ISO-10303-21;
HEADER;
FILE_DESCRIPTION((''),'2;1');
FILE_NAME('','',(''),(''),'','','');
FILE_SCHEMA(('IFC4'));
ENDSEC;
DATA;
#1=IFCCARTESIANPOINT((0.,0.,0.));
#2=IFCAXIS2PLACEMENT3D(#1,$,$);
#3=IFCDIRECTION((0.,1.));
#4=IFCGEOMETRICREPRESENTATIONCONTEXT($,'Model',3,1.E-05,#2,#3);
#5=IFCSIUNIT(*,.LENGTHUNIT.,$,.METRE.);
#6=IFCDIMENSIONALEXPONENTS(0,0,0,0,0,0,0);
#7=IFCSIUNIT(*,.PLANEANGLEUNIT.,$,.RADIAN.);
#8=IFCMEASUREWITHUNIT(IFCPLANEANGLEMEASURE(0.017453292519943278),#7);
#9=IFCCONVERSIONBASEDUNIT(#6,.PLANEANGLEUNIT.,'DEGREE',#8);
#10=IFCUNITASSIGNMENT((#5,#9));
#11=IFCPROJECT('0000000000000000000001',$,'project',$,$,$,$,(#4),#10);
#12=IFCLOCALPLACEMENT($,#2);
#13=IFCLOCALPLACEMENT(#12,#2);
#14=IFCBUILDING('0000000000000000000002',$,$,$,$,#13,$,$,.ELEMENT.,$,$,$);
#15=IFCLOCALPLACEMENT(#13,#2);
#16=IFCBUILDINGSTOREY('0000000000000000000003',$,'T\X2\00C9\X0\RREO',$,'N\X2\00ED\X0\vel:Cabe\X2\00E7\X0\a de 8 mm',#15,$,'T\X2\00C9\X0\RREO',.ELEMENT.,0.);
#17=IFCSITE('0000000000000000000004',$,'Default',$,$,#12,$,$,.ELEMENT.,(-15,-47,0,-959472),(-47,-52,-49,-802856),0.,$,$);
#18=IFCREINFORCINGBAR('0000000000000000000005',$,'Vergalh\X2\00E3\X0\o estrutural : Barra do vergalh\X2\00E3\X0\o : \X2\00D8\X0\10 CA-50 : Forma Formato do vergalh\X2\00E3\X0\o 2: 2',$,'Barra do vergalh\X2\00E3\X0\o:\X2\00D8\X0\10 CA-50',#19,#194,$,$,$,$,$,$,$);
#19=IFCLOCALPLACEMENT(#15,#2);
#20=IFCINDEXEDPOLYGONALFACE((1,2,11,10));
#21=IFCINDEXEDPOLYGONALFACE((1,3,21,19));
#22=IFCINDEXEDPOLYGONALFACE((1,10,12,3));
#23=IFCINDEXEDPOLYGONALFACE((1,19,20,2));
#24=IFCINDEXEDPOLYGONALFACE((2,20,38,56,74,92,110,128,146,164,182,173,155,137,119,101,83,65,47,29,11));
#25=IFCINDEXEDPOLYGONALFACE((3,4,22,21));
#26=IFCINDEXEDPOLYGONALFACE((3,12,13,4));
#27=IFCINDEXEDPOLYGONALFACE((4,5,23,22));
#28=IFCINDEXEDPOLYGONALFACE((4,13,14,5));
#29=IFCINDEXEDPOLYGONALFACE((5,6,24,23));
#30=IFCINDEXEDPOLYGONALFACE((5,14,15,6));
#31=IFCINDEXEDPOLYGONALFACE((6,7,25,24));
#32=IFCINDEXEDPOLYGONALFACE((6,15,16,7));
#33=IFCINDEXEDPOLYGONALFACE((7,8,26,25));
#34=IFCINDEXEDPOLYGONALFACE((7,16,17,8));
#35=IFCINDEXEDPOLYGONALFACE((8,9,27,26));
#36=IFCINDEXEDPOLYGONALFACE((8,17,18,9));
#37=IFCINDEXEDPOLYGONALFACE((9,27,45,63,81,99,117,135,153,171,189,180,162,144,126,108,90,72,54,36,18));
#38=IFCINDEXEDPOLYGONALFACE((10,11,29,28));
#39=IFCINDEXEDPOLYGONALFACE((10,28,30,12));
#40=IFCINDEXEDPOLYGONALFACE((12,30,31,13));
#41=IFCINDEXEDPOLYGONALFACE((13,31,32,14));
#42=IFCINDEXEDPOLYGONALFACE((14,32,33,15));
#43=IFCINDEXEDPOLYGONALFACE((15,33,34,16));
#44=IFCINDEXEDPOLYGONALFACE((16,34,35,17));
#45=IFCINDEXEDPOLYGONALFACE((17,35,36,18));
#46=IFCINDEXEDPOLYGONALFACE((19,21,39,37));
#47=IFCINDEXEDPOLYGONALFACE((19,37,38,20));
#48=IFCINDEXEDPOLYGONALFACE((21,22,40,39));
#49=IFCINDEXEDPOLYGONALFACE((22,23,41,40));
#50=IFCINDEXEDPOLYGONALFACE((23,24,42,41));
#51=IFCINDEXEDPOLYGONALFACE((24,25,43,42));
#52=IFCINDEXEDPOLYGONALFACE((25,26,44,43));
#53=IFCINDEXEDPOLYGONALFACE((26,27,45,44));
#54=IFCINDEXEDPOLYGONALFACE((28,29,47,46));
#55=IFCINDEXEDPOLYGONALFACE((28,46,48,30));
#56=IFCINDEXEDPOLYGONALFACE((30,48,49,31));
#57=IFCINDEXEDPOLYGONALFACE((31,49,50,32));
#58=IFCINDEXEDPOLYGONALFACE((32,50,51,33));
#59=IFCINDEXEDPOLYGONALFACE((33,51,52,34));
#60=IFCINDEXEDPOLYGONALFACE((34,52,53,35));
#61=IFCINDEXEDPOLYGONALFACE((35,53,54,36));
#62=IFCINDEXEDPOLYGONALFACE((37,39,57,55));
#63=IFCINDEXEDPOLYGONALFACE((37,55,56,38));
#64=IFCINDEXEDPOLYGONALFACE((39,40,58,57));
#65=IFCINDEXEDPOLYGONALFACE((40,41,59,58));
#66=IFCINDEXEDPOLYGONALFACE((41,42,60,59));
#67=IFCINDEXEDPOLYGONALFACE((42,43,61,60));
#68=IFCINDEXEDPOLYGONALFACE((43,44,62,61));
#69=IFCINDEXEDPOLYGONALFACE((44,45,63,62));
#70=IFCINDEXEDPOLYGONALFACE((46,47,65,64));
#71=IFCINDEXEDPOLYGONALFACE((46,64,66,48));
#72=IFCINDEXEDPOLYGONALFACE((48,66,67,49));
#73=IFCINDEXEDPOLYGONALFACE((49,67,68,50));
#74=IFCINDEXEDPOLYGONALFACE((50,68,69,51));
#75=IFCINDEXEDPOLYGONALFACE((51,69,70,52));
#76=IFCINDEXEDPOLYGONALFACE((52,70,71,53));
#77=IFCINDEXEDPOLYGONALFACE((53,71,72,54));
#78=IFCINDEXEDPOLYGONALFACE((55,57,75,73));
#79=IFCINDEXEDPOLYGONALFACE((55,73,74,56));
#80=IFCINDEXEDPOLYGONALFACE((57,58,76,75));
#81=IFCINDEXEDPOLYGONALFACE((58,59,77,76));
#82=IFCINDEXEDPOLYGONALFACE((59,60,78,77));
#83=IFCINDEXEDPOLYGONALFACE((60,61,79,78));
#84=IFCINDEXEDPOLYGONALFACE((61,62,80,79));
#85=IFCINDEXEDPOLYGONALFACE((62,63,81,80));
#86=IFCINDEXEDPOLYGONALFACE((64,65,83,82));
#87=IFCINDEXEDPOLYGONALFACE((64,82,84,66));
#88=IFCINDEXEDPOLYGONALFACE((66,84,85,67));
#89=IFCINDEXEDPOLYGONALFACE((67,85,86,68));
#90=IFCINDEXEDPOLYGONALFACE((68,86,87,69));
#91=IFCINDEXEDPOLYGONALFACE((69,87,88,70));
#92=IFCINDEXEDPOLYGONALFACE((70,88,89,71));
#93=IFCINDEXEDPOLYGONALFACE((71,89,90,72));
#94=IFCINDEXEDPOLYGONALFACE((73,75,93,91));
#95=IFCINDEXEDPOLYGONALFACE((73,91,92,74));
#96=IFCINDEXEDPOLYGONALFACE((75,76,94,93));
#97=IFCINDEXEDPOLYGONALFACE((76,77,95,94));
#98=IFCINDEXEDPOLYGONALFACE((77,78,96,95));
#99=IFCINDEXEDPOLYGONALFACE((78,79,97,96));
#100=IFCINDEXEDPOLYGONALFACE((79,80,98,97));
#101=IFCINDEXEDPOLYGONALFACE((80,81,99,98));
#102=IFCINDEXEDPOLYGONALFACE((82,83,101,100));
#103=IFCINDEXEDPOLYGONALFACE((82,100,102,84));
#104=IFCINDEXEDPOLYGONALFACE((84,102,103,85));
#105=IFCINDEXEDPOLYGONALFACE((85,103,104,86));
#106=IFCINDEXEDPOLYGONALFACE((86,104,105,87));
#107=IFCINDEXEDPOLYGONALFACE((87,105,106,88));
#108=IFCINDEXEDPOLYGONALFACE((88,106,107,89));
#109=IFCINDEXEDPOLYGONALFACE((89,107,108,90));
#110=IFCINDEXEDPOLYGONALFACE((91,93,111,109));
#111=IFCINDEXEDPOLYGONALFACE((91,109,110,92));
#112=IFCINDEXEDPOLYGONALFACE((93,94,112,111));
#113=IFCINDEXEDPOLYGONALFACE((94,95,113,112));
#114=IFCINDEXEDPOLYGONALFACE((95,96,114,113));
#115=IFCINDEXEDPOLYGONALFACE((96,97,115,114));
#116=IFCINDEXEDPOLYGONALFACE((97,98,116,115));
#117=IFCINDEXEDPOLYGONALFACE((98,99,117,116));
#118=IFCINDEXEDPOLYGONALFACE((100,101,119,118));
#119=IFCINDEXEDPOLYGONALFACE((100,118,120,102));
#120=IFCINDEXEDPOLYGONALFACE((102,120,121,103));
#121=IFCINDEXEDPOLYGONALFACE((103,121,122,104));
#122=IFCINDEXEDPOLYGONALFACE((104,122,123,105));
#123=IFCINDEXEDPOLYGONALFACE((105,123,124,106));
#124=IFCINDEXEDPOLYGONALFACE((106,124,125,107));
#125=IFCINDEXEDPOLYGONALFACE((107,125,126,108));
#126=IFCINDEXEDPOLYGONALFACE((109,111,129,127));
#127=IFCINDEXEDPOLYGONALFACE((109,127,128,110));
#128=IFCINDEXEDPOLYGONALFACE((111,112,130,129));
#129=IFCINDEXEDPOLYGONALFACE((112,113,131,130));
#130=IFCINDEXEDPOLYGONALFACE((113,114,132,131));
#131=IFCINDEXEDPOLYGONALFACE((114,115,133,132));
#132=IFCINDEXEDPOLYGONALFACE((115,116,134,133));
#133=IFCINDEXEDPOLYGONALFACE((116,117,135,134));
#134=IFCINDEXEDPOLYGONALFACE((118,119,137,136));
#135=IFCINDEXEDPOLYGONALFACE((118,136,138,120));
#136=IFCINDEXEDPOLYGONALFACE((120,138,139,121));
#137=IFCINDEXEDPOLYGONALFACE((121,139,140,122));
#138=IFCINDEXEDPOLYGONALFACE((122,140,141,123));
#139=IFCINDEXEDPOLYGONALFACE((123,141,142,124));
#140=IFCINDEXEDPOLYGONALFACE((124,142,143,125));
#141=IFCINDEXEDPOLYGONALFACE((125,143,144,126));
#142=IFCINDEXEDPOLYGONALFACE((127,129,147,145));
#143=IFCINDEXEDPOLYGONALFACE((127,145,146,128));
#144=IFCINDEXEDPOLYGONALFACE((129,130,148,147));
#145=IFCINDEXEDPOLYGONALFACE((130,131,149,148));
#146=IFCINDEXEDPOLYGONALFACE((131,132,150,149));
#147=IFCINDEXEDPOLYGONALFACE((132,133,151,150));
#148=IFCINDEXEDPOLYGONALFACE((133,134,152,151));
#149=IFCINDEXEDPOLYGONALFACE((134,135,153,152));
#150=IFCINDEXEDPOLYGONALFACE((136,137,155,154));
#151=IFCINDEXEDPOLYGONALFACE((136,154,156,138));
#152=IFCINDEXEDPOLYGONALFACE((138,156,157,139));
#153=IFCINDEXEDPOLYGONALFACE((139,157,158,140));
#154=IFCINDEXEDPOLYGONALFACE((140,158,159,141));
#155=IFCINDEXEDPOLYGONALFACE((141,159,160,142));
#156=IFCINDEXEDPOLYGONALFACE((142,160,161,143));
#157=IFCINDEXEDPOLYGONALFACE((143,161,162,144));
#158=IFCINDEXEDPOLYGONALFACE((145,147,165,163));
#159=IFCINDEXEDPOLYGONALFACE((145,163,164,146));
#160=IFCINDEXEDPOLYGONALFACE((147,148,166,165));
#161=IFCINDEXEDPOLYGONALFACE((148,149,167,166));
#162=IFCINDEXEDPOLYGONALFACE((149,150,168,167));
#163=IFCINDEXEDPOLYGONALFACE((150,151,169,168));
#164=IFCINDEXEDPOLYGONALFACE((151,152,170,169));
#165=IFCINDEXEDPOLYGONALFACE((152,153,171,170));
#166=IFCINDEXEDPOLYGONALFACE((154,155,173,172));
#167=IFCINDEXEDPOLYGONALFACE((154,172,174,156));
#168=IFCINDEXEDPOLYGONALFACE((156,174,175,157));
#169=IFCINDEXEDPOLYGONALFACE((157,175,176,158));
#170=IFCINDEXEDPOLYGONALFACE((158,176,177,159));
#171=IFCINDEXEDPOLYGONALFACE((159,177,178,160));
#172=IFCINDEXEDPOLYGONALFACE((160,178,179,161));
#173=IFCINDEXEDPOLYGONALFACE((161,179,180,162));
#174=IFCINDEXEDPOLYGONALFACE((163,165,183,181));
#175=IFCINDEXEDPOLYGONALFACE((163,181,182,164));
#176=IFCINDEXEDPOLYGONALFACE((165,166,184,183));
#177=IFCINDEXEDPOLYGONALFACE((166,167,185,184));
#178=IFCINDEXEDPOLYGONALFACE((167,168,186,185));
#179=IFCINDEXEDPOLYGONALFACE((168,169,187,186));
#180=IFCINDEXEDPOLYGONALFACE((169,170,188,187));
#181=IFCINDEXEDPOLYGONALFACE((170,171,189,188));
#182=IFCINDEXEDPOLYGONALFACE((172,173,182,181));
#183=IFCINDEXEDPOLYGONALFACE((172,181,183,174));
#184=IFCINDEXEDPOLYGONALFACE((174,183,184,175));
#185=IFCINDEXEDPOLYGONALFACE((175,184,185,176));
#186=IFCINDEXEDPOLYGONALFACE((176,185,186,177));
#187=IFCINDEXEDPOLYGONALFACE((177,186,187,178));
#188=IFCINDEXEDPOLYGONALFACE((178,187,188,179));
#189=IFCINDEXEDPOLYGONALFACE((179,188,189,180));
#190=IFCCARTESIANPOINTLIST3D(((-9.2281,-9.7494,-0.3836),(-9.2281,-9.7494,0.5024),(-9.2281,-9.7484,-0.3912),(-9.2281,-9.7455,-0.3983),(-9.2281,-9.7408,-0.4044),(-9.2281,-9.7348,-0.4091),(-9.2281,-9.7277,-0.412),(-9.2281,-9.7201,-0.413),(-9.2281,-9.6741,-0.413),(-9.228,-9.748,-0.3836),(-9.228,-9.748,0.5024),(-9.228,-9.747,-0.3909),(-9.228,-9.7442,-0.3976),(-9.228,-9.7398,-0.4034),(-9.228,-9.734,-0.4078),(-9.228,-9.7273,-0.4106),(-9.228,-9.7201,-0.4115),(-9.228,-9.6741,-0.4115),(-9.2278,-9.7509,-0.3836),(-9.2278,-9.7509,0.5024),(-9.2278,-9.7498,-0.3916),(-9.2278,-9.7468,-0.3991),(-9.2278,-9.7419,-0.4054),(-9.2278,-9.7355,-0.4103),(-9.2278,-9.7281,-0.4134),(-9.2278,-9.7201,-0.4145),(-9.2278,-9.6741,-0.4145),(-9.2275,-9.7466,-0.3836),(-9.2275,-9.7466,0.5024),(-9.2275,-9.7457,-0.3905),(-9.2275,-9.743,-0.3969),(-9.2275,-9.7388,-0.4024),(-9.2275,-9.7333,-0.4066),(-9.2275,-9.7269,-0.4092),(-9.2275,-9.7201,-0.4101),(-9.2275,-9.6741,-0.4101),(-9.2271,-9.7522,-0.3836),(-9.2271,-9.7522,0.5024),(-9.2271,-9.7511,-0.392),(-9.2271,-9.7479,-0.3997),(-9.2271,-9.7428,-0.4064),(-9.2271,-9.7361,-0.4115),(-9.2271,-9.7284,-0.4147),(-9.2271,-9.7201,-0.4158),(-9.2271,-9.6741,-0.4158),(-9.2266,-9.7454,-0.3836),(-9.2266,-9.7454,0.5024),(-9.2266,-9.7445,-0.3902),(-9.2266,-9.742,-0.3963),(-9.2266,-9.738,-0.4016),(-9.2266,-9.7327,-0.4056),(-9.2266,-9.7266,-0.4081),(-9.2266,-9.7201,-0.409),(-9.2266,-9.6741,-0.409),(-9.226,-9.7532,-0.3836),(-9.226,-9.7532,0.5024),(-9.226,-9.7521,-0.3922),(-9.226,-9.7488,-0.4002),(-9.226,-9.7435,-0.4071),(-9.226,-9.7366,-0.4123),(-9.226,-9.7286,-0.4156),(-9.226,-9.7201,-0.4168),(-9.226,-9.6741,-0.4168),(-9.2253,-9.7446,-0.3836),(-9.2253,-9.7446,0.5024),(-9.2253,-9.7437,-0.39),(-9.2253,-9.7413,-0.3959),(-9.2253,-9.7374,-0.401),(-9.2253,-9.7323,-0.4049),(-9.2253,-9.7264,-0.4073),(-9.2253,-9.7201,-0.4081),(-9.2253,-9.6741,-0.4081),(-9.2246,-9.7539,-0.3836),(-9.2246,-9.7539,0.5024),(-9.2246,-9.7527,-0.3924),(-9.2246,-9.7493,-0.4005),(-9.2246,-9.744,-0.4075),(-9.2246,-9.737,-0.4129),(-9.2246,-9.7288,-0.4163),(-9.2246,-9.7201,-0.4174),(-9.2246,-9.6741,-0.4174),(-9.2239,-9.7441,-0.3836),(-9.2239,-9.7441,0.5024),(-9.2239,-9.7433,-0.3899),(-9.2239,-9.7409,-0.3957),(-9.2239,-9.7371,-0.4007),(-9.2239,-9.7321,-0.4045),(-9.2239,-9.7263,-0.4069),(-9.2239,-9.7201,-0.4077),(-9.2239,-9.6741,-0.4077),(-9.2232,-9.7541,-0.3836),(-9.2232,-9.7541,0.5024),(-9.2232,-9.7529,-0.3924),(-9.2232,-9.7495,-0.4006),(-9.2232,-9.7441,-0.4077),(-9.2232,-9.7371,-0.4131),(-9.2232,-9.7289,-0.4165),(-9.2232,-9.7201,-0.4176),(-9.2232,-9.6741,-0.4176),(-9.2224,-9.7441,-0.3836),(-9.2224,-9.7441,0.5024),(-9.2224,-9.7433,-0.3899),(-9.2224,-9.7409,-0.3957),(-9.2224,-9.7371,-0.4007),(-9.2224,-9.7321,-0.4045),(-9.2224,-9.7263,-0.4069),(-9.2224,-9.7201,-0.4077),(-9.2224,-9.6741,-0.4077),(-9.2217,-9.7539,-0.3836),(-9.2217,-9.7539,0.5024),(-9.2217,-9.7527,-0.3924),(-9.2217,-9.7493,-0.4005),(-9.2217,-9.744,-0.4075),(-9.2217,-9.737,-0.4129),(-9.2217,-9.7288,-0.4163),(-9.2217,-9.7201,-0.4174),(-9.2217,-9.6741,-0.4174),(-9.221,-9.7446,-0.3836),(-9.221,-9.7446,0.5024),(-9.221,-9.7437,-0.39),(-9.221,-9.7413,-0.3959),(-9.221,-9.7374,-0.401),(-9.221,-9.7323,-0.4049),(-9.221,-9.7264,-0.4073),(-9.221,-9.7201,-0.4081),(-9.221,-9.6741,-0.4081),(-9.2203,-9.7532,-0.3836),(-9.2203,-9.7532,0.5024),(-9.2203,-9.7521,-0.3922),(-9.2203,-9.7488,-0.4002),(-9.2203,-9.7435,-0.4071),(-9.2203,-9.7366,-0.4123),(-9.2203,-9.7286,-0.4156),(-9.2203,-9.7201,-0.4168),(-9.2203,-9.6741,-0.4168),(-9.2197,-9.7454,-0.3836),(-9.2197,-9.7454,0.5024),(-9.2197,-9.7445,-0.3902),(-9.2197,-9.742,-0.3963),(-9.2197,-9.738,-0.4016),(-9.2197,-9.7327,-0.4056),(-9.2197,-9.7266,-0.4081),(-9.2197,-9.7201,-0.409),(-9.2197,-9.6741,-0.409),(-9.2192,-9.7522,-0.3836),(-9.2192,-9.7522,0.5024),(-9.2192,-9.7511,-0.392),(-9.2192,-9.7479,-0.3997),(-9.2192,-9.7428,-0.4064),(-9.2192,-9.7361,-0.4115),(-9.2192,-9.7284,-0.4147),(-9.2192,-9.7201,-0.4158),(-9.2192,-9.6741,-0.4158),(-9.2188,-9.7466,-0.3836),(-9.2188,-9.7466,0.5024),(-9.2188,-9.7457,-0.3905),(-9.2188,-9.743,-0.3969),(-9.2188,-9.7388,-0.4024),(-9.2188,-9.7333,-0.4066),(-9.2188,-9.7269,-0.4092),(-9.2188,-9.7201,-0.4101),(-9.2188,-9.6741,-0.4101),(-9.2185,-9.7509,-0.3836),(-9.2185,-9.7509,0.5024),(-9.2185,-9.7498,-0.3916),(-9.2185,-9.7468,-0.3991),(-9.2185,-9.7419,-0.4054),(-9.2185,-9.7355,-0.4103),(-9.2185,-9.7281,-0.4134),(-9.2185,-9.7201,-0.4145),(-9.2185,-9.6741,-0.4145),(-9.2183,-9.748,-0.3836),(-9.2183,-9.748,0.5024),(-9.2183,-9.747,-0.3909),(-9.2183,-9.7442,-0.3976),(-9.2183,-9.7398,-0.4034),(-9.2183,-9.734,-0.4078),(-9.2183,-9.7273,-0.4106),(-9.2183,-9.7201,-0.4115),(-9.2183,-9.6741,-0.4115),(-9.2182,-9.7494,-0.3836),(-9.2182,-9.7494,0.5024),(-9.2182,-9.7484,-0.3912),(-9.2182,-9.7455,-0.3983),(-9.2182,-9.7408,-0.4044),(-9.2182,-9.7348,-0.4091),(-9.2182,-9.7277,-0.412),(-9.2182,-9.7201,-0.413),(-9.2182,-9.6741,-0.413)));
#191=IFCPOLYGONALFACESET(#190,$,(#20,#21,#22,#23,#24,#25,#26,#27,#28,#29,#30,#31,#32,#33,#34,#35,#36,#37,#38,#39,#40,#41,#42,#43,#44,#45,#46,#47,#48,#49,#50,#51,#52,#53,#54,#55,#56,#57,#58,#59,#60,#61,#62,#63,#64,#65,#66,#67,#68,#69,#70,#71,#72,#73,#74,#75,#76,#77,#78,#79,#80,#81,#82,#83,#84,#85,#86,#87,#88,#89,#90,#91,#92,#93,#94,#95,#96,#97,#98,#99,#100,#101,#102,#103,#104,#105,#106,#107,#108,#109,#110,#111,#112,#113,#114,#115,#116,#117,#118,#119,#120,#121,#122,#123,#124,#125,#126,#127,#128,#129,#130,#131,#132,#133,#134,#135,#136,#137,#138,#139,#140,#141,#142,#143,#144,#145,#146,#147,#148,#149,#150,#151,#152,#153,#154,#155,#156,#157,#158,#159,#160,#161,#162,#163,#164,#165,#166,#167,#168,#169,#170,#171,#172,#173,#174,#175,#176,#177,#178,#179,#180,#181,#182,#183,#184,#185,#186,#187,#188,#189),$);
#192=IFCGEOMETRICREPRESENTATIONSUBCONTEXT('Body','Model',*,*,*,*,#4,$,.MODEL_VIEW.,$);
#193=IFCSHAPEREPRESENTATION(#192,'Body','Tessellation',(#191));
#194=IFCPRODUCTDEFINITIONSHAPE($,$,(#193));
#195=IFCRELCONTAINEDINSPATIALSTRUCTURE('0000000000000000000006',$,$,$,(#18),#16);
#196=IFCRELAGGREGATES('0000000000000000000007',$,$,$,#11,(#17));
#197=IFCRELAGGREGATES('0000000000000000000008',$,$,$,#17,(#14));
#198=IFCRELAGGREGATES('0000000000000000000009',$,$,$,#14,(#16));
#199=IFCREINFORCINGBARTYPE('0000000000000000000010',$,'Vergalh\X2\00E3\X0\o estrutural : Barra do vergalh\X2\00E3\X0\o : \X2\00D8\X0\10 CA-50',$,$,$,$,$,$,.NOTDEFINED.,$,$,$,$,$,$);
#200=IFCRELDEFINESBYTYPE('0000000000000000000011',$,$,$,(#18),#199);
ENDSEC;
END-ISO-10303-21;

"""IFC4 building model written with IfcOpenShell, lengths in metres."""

from ifc_helpers import new_model, entity, si_unit, converted_unit, direction, origin, place, context, subcontext, project, spatial, type_object, element, save


model = new_model("IFC4")

# Units and contexts
model_context = context("Model", 3, precision=1e-05, world=origin(), true_north=direction((0.0, 1.0)))
body_context = subcontext(model_context, "Body", "Model", "MODEL_VIEW")
ifc_project = project(units=[si_unit("LENGTHUNIT", "METRE"), converted_unit("PLANEANGLEUNIT", "DEGREE", entity("IfcPlaneAngleMeasure", 0.017453292519943278), si_unit("PLANEANGLEUNIT", "RADIAN"), dimensions=[0, 0, 0, 0, 0, 0, 0])], contexts=[model_context])

# Site, building, storey
site_placement = place(None, origin())
site = spatial("IfcSite", under=ifc_project, at=site_placement, Name="Default", CompositionType="ELEMENT", RefLatitude=(-15, -47, 0, -959472), RefLongitude=(-47, -52, -49, -802856), RefElevation=0.0)
building_placement = place(site_placement, origin())
building = spatial("IfcBuilding", under=site, at=building_placement, CompositionType="ELEMENT")
storey_placement = place(building_placement, origin())
storey = spatial("IfcBuildingStorey", under=building, at=storey_placement, Name="TÉRREO", ObjectType="Nível:Cabeça de 8 mm", LongName="TÉRREO", CompositionType="ELEMENT", Elevation=0.0)

# Reinforcing bar
reinforcing_bar_type_1 = type_object("IfcReinforcingBarType", Name="Vergalhão estrutural : Barra do vergalhão : Ø10 CA-50", PredefinedType="NOTDEFINED")
reinforcing_bar_1_placement = place(storey_placement, origin())
element("IfcReinforcingBar", 1, at=reinforcing_bar_1_placement, inside=storey, type_object=reinforcing_bar_type_1, Name="Vergalhão estrutural : Barra do vergalhão : Ø10 CA-50 : Forma Formato do vergalhão 2: 2", ObjectType="Barra do vergalhão:Ø10 CA-50", context=body_context, shape_type="AdvancedSweptSolid", body=[
    entity("IfcSweptDiskSolid", entity("IfcIndexedPolyCurve", entity("IfcCartesianPointList3D", [[-9.2232, -9.6741, -0.4126], [-9.2232, -9.7201, -0.4126], [-9.2232, -9.7406, -0.4042], [-9.2232, -9.7491, -0.3836], [-9.2232, -9.7491, 0.5024]]), [entity("IfcLineIndex", [1, 2]), entity("IfcArcIndex", [2, 3, 4]), entity("IfcLineIndex", [4, 5])], False), 0.005, None, 0.0, 92.0),
])

save(model, "model.ifc")
